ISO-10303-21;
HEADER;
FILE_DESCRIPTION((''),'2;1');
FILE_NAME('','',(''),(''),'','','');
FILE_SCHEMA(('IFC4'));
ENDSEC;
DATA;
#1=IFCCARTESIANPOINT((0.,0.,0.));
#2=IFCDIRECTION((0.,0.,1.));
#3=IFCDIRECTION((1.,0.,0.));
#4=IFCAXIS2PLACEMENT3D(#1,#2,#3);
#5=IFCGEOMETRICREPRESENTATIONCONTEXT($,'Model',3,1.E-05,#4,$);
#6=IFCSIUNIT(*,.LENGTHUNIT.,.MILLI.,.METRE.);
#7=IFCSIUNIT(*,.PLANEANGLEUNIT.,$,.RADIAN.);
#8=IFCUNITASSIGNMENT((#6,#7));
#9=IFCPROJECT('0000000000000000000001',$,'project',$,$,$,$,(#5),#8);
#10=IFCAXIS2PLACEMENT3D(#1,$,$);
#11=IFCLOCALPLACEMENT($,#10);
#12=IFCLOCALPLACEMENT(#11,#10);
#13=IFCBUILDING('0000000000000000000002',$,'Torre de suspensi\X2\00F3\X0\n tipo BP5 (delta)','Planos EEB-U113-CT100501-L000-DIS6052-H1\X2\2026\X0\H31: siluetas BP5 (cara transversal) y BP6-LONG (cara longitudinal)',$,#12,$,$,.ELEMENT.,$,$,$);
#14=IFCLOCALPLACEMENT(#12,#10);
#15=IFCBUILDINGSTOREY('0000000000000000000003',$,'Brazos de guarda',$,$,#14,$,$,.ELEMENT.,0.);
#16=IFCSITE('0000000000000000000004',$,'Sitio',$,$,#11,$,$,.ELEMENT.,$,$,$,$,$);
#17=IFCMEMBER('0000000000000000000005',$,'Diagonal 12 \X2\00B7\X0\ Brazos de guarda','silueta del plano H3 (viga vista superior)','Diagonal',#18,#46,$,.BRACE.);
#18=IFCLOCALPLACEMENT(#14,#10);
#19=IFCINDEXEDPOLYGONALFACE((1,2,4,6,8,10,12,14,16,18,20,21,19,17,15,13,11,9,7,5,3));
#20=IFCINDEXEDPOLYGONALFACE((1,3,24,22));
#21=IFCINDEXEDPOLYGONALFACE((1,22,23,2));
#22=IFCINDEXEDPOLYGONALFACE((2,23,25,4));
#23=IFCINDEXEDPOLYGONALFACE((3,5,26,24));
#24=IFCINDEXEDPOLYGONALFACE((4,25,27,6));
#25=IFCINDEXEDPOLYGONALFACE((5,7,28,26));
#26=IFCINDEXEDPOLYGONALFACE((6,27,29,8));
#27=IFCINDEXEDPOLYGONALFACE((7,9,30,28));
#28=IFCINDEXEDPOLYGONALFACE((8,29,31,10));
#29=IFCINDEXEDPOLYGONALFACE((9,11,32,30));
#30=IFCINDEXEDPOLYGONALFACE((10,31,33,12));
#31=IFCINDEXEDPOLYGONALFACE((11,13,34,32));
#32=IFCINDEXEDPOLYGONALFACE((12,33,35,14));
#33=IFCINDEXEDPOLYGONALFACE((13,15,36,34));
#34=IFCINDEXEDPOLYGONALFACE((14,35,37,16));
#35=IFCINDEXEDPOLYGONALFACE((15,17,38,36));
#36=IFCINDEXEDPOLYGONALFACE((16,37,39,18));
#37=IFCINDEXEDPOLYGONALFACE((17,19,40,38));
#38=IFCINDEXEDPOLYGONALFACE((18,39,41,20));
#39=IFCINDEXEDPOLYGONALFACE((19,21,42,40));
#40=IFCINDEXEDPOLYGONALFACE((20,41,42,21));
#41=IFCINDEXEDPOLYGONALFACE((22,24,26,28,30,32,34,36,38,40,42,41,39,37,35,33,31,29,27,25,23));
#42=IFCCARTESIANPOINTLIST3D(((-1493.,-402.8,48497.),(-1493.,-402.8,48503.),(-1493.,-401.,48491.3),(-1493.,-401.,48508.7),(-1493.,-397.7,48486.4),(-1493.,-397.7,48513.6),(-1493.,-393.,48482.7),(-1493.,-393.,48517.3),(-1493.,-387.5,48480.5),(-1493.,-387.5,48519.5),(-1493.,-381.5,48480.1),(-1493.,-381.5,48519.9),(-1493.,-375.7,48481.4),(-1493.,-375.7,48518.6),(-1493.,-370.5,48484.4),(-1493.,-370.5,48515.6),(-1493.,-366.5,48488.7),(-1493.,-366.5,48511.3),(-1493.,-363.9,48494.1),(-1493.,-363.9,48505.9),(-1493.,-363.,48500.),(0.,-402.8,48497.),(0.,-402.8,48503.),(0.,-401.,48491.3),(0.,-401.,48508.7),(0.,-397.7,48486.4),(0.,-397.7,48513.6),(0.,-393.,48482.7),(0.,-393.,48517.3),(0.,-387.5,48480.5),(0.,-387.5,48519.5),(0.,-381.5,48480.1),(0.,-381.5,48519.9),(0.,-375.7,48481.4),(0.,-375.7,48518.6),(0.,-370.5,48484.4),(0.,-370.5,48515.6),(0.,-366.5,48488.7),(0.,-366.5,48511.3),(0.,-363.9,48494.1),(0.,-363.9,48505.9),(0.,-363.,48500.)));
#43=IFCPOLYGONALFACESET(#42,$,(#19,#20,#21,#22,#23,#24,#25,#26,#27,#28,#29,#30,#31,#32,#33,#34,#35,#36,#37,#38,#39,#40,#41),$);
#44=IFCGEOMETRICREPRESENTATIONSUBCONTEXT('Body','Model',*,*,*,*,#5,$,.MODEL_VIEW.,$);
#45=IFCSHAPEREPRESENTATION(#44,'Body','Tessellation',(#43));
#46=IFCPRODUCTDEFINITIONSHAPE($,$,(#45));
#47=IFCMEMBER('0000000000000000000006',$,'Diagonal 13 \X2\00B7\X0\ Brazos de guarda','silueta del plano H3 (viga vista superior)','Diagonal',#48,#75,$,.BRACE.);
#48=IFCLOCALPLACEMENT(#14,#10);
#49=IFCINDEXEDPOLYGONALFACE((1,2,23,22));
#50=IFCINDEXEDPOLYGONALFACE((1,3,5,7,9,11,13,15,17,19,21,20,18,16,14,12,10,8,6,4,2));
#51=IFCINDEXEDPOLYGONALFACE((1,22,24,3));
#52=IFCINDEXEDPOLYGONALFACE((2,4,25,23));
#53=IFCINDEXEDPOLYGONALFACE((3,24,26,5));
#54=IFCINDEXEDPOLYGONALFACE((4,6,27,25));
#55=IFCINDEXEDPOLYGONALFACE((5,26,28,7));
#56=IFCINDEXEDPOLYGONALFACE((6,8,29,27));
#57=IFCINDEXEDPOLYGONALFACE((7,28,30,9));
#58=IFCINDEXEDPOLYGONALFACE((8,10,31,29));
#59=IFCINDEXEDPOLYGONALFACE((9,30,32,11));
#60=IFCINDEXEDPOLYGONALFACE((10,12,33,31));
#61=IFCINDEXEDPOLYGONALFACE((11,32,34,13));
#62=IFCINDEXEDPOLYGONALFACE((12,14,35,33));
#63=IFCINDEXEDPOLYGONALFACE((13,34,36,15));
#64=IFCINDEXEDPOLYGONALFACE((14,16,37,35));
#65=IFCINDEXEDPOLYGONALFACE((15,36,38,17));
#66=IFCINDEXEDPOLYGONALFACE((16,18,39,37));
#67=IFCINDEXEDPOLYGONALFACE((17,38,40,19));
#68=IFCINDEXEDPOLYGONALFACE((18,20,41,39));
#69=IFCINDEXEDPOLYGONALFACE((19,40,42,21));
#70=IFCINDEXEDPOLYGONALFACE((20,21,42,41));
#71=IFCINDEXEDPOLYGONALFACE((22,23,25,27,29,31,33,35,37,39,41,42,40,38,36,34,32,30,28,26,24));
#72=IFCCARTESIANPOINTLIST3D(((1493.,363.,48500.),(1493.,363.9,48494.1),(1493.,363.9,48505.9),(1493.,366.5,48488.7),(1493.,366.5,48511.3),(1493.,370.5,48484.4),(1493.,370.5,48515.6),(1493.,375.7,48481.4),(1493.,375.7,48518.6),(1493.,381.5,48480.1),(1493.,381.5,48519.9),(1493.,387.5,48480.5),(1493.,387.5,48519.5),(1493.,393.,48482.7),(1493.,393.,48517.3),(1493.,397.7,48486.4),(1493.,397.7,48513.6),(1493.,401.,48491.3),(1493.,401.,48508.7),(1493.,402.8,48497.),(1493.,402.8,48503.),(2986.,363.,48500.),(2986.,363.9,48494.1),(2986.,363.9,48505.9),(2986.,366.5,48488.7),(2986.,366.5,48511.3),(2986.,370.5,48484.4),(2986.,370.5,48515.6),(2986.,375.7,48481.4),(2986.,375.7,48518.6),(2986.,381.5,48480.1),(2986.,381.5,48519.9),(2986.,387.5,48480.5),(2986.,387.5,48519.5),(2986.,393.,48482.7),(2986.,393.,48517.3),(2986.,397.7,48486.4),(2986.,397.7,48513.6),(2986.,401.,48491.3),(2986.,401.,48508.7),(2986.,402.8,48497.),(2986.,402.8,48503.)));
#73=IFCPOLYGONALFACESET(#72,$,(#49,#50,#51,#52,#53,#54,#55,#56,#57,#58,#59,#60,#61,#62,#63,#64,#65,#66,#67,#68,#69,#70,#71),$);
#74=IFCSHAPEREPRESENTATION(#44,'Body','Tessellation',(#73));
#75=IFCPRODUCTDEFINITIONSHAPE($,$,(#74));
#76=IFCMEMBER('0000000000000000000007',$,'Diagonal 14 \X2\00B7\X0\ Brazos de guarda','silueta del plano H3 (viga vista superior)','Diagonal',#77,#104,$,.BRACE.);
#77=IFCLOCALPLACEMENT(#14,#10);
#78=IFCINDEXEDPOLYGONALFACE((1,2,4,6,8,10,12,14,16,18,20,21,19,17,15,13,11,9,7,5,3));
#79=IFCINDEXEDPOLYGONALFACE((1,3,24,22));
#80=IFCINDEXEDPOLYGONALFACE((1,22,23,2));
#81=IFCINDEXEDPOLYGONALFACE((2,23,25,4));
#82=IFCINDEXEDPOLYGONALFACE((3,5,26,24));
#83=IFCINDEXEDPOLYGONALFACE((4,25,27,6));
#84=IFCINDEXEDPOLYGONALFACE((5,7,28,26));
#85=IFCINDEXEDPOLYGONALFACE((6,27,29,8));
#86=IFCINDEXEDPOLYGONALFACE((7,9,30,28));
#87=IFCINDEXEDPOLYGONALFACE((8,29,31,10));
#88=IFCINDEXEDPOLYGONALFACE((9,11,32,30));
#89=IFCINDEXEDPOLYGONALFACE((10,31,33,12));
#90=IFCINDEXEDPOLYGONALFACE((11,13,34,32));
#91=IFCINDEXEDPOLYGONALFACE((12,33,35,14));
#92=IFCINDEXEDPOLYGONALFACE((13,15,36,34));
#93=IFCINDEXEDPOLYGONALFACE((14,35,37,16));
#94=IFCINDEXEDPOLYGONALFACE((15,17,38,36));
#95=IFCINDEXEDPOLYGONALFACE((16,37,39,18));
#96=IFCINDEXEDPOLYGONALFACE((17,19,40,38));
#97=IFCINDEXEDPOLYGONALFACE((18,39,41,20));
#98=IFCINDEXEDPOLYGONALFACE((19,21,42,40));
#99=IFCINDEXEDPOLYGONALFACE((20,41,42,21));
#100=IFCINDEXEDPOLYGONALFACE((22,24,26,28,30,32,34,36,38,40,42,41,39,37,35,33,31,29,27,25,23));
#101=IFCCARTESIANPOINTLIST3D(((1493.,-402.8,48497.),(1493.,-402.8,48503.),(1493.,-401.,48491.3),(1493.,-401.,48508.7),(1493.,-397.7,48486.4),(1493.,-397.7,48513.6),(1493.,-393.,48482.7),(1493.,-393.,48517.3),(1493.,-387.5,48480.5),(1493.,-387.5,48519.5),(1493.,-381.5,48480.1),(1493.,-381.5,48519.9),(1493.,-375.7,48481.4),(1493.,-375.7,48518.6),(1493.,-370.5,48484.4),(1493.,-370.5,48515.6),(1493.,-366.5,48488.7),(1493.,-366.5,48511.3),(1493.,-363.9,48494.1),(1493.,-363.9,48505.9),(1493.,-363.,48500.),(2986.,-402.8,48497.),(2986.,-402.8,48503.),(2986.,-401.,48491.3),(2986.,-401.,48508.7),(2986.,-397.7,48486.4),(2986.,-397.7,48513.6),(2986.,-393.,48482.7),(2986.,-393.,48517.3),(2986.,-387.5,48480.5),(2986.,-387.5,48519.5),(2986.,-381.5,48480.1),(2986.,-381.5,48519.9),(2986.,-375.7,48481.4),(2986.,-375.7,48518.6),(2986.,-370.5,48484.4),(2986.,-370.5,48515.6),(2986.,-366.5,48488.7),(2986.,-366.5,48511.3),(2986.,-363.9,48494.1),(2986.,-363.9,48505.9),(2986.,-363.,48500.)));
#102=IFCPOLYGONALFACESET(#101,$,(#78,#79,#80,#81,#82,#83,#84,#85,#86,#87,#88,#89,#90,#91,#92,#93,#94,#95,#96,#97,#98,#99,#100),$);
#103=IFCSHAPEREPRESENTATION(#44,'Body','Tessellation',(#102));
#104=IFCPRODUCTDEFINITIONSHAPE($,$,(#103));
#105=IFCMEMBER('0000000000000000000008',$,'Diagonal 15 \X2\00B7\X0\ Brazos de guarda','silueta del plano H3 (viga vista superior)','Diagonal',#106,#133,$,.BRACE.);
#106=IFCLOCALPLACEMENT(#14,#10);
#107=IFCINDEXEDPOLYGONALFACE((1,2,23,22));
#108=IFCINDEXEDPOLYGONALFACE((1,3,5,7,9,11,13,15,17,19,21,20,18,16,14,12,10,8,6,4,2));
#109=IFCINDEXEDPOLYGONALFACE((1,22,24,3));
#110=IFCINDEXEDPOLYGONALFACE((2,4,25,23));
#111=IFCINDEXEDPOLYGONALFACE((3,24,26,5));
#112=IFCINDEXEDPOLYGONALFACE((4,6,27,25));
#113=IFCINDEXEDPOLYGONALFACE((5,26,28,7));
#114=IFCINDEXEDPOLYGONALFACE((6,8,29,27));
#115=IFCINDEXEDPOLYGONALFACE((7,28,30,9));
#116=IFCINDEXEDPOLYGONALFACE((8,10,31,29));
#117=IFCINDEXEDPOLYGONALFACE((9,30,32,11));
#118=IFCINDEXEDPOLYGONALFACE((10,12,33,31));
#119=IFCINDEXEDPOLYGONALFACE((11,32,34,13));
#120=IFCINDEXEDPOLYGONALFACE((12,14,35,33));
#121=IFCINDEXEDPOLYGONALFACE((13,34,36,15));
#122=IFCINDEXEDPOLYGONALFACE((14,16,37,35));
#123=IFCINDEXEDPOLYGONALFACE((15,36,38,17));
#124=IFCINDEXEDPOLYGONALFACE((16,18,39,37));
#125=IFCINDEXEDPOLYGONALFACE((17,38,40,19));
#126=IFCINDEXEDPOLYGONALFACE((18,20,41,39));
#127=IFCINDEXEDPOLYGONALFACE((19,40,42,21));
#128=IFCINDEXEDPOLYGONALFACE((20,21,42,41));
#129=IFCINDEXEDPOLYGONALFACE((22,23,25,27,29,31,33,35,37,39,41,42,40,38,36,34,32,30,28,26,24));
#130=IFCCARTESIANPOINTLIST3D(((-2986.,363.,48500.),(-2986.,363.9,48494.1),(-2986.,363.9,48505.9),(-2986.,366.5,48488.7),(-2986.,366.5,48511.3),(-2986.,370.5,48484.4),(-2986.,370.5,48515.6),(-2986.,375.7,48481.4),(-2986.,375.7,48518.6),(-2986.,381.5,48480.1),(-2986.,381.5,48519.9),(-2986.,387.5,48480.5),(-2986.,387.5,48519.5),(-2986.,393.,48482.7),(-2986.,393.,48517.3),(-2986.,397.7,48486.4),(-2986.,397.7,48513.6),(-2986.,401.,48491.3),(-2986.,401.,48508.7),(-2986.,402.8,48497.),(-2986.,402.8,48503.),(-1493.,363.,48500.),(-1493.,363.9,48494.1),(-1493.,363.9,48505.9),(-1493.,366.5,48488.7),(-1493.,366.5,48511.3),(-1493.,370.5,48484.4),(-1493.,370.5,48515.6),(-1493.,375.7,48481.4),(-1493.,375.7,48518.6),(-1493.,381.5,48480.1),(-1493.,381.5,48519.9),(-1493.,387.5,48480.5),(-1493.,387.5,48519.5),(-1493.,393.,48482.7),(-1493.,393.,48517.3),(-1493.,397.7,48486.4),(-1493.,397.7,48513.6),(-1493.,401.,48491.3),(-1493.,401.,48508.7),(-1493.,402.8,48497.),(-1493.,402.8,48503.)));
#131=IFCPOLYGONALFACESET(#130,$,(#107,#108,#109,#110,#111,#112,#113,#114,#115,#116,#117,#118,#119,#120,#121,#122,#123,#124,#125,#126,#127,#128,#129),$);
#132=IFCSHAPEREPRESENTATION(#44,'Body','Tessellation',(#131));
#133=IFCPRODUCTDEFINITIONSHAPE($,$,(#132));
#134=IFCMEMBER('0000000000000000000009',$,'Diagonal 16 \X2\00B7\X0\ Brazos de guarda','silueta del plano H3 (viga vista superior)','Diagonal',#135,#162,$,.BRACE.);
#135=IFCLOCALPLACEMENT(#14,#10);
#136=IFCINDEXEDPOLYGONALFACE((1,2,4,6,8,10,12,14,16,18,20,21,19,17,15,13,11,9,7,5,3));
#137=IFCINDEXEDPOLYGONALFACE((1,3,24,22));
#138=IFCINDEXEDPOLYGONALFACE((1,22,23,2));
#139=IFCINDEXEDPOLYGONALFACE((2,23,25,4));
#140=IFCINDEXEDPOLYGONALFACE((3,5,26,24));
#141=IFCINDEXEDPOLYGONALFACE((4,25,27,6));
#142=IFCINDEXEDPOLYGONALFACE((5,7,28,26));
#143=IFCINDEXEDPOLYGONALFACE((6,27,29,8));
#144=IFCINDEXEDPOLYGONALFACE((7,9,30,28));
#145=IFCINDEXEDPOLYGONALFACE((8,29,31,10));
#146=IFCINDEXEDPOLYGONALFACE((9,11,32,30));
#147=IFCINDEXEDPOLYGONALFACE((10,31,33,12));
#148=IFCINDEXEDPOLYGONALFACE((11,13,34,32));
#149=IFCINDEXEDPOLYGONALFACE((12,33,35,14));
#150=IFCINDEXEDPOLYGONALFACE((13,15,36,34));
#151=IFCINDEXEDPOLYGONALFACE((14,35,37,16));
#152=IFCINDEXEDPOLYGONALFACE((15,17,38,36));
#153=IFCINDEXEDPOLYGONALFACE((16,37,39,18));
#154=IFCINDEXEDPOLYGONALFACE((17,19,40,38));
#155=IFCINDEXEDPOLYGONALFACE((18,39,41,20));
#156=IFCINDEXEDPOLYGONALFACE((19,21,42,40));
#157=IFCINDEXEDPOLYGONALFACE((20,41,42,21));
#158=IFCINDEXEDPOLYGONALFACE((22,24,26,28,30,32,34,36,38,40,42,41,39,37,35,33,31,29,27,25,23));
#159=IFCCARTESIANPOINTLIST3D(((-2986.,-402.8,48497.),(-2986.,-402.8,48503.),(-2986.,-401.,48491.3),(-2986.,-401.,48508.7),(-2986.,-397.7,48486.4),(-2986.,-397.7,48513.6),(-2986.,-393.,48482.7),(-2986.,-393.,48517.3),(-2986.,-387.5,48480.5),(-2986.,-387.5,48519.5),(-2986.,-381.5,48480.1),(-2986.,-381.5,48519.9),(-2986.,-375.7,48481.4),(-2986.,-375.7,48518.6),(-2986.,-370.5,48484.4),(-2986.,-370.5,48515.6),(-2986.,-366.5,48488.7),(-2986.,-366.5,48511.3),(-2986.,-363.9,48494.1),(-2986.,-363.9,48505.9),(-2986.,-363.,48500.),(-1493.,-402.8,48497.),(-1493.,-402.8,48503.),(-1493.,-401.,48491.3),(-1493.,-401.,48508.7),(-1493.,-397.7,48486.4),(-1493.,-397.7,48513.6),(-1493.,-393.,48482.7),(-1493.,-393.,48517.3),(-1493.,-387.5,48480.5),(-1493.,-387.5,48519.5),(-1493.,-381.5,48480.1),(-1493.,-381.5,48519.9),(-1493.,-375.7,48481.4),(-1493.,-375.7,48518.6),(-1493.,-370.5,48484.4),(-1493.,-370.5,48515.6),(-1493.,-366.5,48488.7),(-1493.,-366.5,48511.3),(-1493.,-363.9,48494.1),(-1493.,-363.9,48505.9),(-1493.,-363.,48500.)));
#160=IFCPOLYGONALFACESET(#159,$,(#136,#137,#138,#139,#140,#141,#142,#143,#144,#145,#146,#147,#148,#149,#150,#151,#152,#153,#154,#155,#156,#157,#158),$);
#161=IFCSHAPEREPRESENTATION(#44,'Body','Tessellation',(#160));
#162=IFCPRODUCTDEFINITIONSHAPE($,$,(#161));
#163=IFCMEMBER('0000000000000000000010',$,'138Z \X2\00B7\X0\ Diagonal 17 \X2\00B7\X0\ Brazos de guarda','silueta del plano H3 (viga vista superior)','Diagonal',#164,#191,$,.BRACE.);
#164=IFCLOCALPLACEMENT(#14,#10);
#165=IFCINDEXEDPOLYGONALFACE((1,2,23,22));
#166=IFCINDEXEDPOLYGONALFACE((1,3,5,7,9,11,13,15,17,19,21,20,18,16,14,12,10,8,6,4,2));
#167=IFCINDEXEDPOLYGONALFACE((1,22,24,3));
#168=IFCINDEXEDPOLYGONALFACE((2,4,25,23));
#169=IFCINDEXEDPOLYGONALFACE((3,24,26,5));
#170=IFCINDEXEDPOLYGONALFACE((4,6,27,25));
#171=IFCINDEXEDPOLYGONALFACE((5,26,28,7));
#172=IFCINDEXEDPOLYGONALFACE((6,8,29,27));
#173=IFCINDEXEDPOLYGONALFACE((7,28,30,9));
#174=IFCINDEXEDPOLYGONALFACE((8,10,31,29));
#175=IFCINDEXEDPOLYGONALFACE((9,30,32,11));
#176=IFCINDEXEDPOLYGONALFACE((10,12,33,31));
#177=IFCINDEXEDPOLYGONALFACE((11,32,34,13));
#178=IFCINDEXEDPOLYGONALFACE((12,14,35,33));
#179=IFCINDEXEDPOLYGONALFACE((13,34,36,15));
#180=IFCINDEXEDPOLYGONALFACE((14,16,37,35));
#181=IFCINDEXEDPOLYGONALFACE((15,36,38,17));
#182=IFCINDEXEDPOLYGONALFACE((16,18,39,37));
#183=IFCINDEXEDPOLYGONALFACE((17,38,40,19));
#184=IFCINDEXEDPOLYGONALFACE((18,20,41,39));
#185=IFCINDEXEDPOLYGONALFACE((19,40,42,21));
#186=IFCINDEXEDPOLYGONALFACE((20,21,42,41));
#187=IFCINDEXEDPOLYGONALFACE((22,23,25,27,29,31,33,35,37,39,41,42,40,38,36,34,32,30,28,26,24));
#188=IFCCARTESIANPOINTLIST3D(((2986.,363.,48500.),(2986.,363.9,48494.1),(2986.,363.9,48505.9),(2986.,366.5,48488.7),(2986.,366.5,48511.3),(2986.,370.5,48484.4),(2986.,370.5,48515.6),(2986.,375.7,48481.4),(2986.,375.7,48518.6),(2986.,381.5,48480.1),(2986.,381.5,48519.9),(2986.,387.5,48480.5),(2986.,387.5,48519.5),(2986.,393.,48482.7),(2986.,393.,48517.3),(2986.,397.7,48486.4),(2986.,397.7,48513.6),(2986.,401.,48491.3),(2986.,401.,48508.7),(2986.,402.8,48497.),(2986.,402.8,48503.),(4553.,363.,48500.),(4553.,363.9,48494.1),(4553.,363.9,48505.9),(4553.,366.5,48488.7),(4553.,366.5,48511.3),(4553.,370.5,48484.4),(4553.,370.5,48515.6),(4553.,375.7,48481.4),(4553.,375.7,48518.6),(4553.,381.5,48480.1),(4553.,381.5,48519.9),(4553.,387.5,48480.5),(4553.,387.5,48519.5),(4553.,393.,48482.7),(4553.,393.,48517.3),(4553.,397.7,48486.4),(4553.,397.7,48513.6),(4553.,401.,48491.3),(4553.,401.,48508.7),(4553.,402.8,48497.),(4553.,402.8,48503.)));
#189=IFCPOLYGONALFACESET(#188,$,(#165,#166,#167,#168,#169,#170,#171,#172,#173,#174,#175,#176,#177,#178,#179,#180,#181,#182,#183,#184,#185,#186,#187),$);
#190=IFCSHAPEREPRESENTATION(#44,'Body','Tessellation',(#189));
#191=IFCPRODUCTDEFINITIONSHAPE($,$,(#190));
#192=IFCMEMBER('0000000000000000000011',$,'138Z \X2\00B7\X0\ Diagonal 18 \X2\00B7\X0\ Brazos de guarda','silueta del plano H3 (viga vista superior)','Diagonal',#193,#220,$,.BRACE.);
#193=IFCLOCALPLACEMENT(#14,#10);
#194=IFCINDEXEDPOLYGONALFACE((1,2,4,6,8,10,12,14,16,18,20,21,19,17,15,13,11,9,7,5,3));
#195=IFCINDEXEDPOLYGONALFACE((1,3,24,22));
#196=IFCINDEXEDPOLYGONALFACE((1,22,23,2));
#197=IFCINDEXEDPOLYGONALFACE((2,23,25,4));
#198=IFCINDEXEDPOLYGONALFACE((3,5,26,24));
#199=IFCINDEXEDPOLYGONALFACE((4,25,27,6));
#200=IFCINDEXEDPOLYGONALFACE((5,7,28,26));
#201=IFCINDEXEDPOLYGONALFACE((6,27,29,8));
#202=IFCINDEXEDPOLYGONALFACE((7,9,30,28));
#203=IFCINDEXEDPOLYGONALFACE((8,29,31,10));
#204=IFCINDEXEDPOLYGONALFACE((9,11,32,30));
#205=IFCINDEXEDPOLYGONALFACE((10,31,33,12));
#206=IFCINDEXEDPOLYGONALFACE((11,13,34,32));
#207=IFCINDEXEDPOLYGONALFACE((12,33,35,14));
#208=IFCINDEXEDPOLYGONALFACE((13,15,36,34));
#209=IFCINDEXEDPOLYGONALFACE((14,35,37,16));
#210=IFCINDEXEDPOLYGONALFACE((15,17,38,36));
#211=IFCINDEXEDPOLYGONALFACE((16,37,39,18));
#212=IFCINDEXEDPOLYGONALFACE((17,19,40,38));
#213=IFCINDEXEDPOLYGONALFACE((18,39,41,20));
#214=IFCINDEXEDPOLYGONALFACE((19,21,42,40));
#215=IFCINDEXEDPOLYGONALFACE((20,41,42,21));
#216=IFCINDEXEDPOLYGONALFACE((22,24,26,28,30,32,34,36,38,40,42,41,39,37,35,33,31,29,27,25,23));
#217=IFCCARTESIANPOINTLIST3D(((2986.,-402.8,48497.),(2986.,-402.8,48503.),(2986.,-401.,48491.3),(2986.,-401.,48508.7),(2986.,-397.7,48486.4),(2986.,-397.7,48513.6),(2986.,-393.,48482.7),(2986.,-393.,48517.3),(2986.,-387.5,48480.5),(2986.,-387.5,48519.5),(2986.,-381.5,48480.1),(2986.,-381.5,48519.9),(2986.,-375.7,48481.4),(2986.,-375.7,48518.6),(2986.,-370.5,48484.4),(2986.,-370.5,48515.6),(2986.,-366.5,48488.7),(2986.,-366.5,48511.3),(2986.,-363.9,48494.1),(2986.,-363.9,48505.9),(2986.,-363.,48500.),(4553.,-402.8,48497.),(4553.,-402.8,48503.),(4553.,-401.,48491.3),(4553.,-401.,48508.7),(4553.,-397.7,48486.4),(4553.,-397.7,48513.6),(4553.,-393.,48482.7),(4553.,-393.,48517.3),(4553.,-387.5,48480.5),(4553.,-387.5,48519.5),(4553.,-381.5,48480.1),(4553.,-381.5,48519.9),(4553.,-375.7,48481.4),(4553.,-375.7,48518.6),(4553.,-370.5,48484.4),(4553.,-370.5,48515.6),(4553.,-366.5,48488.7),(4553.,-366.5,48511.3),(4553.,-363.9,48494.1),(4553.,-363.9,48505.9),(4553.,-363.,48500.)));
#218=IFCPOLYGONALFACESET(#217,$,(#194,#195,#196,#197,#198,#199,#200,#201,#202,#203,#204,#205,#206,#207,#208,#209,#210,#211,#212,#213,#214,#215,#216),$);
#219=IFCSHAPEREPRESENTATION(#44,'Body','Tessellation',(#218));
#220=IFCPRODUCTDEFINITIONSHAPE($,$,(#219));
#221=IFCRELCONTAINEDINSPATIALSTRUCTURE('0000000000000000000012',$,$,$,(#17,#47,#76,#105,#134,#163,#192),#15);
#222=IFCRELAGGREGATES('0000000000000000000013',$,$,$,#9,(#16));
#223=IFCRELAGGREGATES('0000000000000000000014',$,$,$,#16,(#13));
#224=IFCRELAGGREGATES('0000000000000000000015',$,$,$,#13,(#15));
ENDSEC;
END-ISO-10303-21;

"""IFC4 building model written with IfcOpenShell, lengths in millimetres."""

from ifc_helpers import new_model, si_unit, frame, origin, origin_with_axes, place, context, subcontext, project, spatial, circle, extrude, element, save


model = new_model("IFC4")

# Units and contexts
model_context = context("Model", 3, precision=1e-05, world=origin_with_axes())
body_context = subcontext(model_context, "Body", "Model", "MODEL_VIEW")
ifc_project = project(units=[si_unit("LENGTHUNIT", "METRE", prefix="MILLI"), si_unit("PLANEANGLEUNIT", "RADIAN")], contexts=[model_context])

# Site, building, storey
site_placement = place(None, origin())
site = spatial("IfcSite", under=ifc_project, at=site_placement, Name="Sitio", CompositionType="ELEMENT")
building_placement = place(site_placement, origin())
building = spatial("IfcBuilding", under=site, at=building_placement, Name="Torre de suspensión tipo BP5 (delta)", Description="Planos EEB-U113-CT100501-L000-DIS6052-H1…H31: siluetas BP5 (cara transversal) y BP6-LONG (cara longitudinal)", CompositionType="ELEMENT")
storey_placement = place(building_placement, origin())
storey = spatial("IfcBuildingStorey", under=building, at=storey_placement, Name="Brazos de guarda", CompositionType="ELEMENT", Elevation=0.0)

# Members
for number, where, z_axis, x_axis, name in (
    (1, (0.0, -383.0, 48500.0), (-1.0, 0.0, 0.0), (0.0, 1.0, 0.0), "Diagonal 12 · Brazos de guarda"),
    (2, (1493.0, 383.0, 48500.0), (1.0, 0.0, 0.0), (0.0, -1.0, 0.0), "Diagonal 13 · Brazos de guarda"),
    (3, (1493.0, -383.0, 48500.0), (1.0, 0.0, 0.0), (0.0, 1.0, 0.0), "Diagonal 14 · Brazos de guarda"),
    (4, (-1493.0, 383.0, 48500.0), (-1.0, 0.0, 0.0), (0.0, -1.0, 0.0), "Diagonal 15 · Brazos de guarda"),
    (5, (-1493.0, -383.0, 48500.0), (-1.0, 0.0, 0.0), (0.0, 1.0, 0.0), "Diagonal 16 · Brazos de guarda"),
):
    element("IfcMember", number, at=place(storey_placement, frame(where, z_axis=z_axis, x_axis=x_axis)), inside=storey, Name=name, Description="silueta del plano H3 (viga vista superior)", ObjectType="Diagonal", PredefinedType="BRACE", context=body_context, shape_type="SweptSolid", body=[
        extrude(circle(Radius=20.0), None, (0.0, 0.0, 1.0), 1493.0),
    ])
for number, where, z_axis, x_axis, name in (
    (6, (2986.0, 383.0, 48500.0), (1.0, 0.0, 0.0), (0.0, -1.0, 0.0), "138Z · Diagonal 17 · Brazos de guarda"),
    (7, (2986.0, -383.0, 48500.0), (1.0, 0.0, 0.0), (0.0, 1.0, 0.0), "138Z · Diagonal 18 · Brazos de guarda"),
):
    element("IfcMember", number, at=place(storey_placement, frame(where, z_axis=z_axis, x_axis=x_axis)), inside=storey, Name=name, Description="silueta del plano H3 (viga vista superior)", ObjectType="Diagonal", PredefinedType="BRACE", context=body_context, shape_type="SweptSolid", body=[
        extrude(circle(Radius=20.0), None, (0.0, 0.0, 1.0), 1567.0),
    ])

save(model, "model.ifc")
